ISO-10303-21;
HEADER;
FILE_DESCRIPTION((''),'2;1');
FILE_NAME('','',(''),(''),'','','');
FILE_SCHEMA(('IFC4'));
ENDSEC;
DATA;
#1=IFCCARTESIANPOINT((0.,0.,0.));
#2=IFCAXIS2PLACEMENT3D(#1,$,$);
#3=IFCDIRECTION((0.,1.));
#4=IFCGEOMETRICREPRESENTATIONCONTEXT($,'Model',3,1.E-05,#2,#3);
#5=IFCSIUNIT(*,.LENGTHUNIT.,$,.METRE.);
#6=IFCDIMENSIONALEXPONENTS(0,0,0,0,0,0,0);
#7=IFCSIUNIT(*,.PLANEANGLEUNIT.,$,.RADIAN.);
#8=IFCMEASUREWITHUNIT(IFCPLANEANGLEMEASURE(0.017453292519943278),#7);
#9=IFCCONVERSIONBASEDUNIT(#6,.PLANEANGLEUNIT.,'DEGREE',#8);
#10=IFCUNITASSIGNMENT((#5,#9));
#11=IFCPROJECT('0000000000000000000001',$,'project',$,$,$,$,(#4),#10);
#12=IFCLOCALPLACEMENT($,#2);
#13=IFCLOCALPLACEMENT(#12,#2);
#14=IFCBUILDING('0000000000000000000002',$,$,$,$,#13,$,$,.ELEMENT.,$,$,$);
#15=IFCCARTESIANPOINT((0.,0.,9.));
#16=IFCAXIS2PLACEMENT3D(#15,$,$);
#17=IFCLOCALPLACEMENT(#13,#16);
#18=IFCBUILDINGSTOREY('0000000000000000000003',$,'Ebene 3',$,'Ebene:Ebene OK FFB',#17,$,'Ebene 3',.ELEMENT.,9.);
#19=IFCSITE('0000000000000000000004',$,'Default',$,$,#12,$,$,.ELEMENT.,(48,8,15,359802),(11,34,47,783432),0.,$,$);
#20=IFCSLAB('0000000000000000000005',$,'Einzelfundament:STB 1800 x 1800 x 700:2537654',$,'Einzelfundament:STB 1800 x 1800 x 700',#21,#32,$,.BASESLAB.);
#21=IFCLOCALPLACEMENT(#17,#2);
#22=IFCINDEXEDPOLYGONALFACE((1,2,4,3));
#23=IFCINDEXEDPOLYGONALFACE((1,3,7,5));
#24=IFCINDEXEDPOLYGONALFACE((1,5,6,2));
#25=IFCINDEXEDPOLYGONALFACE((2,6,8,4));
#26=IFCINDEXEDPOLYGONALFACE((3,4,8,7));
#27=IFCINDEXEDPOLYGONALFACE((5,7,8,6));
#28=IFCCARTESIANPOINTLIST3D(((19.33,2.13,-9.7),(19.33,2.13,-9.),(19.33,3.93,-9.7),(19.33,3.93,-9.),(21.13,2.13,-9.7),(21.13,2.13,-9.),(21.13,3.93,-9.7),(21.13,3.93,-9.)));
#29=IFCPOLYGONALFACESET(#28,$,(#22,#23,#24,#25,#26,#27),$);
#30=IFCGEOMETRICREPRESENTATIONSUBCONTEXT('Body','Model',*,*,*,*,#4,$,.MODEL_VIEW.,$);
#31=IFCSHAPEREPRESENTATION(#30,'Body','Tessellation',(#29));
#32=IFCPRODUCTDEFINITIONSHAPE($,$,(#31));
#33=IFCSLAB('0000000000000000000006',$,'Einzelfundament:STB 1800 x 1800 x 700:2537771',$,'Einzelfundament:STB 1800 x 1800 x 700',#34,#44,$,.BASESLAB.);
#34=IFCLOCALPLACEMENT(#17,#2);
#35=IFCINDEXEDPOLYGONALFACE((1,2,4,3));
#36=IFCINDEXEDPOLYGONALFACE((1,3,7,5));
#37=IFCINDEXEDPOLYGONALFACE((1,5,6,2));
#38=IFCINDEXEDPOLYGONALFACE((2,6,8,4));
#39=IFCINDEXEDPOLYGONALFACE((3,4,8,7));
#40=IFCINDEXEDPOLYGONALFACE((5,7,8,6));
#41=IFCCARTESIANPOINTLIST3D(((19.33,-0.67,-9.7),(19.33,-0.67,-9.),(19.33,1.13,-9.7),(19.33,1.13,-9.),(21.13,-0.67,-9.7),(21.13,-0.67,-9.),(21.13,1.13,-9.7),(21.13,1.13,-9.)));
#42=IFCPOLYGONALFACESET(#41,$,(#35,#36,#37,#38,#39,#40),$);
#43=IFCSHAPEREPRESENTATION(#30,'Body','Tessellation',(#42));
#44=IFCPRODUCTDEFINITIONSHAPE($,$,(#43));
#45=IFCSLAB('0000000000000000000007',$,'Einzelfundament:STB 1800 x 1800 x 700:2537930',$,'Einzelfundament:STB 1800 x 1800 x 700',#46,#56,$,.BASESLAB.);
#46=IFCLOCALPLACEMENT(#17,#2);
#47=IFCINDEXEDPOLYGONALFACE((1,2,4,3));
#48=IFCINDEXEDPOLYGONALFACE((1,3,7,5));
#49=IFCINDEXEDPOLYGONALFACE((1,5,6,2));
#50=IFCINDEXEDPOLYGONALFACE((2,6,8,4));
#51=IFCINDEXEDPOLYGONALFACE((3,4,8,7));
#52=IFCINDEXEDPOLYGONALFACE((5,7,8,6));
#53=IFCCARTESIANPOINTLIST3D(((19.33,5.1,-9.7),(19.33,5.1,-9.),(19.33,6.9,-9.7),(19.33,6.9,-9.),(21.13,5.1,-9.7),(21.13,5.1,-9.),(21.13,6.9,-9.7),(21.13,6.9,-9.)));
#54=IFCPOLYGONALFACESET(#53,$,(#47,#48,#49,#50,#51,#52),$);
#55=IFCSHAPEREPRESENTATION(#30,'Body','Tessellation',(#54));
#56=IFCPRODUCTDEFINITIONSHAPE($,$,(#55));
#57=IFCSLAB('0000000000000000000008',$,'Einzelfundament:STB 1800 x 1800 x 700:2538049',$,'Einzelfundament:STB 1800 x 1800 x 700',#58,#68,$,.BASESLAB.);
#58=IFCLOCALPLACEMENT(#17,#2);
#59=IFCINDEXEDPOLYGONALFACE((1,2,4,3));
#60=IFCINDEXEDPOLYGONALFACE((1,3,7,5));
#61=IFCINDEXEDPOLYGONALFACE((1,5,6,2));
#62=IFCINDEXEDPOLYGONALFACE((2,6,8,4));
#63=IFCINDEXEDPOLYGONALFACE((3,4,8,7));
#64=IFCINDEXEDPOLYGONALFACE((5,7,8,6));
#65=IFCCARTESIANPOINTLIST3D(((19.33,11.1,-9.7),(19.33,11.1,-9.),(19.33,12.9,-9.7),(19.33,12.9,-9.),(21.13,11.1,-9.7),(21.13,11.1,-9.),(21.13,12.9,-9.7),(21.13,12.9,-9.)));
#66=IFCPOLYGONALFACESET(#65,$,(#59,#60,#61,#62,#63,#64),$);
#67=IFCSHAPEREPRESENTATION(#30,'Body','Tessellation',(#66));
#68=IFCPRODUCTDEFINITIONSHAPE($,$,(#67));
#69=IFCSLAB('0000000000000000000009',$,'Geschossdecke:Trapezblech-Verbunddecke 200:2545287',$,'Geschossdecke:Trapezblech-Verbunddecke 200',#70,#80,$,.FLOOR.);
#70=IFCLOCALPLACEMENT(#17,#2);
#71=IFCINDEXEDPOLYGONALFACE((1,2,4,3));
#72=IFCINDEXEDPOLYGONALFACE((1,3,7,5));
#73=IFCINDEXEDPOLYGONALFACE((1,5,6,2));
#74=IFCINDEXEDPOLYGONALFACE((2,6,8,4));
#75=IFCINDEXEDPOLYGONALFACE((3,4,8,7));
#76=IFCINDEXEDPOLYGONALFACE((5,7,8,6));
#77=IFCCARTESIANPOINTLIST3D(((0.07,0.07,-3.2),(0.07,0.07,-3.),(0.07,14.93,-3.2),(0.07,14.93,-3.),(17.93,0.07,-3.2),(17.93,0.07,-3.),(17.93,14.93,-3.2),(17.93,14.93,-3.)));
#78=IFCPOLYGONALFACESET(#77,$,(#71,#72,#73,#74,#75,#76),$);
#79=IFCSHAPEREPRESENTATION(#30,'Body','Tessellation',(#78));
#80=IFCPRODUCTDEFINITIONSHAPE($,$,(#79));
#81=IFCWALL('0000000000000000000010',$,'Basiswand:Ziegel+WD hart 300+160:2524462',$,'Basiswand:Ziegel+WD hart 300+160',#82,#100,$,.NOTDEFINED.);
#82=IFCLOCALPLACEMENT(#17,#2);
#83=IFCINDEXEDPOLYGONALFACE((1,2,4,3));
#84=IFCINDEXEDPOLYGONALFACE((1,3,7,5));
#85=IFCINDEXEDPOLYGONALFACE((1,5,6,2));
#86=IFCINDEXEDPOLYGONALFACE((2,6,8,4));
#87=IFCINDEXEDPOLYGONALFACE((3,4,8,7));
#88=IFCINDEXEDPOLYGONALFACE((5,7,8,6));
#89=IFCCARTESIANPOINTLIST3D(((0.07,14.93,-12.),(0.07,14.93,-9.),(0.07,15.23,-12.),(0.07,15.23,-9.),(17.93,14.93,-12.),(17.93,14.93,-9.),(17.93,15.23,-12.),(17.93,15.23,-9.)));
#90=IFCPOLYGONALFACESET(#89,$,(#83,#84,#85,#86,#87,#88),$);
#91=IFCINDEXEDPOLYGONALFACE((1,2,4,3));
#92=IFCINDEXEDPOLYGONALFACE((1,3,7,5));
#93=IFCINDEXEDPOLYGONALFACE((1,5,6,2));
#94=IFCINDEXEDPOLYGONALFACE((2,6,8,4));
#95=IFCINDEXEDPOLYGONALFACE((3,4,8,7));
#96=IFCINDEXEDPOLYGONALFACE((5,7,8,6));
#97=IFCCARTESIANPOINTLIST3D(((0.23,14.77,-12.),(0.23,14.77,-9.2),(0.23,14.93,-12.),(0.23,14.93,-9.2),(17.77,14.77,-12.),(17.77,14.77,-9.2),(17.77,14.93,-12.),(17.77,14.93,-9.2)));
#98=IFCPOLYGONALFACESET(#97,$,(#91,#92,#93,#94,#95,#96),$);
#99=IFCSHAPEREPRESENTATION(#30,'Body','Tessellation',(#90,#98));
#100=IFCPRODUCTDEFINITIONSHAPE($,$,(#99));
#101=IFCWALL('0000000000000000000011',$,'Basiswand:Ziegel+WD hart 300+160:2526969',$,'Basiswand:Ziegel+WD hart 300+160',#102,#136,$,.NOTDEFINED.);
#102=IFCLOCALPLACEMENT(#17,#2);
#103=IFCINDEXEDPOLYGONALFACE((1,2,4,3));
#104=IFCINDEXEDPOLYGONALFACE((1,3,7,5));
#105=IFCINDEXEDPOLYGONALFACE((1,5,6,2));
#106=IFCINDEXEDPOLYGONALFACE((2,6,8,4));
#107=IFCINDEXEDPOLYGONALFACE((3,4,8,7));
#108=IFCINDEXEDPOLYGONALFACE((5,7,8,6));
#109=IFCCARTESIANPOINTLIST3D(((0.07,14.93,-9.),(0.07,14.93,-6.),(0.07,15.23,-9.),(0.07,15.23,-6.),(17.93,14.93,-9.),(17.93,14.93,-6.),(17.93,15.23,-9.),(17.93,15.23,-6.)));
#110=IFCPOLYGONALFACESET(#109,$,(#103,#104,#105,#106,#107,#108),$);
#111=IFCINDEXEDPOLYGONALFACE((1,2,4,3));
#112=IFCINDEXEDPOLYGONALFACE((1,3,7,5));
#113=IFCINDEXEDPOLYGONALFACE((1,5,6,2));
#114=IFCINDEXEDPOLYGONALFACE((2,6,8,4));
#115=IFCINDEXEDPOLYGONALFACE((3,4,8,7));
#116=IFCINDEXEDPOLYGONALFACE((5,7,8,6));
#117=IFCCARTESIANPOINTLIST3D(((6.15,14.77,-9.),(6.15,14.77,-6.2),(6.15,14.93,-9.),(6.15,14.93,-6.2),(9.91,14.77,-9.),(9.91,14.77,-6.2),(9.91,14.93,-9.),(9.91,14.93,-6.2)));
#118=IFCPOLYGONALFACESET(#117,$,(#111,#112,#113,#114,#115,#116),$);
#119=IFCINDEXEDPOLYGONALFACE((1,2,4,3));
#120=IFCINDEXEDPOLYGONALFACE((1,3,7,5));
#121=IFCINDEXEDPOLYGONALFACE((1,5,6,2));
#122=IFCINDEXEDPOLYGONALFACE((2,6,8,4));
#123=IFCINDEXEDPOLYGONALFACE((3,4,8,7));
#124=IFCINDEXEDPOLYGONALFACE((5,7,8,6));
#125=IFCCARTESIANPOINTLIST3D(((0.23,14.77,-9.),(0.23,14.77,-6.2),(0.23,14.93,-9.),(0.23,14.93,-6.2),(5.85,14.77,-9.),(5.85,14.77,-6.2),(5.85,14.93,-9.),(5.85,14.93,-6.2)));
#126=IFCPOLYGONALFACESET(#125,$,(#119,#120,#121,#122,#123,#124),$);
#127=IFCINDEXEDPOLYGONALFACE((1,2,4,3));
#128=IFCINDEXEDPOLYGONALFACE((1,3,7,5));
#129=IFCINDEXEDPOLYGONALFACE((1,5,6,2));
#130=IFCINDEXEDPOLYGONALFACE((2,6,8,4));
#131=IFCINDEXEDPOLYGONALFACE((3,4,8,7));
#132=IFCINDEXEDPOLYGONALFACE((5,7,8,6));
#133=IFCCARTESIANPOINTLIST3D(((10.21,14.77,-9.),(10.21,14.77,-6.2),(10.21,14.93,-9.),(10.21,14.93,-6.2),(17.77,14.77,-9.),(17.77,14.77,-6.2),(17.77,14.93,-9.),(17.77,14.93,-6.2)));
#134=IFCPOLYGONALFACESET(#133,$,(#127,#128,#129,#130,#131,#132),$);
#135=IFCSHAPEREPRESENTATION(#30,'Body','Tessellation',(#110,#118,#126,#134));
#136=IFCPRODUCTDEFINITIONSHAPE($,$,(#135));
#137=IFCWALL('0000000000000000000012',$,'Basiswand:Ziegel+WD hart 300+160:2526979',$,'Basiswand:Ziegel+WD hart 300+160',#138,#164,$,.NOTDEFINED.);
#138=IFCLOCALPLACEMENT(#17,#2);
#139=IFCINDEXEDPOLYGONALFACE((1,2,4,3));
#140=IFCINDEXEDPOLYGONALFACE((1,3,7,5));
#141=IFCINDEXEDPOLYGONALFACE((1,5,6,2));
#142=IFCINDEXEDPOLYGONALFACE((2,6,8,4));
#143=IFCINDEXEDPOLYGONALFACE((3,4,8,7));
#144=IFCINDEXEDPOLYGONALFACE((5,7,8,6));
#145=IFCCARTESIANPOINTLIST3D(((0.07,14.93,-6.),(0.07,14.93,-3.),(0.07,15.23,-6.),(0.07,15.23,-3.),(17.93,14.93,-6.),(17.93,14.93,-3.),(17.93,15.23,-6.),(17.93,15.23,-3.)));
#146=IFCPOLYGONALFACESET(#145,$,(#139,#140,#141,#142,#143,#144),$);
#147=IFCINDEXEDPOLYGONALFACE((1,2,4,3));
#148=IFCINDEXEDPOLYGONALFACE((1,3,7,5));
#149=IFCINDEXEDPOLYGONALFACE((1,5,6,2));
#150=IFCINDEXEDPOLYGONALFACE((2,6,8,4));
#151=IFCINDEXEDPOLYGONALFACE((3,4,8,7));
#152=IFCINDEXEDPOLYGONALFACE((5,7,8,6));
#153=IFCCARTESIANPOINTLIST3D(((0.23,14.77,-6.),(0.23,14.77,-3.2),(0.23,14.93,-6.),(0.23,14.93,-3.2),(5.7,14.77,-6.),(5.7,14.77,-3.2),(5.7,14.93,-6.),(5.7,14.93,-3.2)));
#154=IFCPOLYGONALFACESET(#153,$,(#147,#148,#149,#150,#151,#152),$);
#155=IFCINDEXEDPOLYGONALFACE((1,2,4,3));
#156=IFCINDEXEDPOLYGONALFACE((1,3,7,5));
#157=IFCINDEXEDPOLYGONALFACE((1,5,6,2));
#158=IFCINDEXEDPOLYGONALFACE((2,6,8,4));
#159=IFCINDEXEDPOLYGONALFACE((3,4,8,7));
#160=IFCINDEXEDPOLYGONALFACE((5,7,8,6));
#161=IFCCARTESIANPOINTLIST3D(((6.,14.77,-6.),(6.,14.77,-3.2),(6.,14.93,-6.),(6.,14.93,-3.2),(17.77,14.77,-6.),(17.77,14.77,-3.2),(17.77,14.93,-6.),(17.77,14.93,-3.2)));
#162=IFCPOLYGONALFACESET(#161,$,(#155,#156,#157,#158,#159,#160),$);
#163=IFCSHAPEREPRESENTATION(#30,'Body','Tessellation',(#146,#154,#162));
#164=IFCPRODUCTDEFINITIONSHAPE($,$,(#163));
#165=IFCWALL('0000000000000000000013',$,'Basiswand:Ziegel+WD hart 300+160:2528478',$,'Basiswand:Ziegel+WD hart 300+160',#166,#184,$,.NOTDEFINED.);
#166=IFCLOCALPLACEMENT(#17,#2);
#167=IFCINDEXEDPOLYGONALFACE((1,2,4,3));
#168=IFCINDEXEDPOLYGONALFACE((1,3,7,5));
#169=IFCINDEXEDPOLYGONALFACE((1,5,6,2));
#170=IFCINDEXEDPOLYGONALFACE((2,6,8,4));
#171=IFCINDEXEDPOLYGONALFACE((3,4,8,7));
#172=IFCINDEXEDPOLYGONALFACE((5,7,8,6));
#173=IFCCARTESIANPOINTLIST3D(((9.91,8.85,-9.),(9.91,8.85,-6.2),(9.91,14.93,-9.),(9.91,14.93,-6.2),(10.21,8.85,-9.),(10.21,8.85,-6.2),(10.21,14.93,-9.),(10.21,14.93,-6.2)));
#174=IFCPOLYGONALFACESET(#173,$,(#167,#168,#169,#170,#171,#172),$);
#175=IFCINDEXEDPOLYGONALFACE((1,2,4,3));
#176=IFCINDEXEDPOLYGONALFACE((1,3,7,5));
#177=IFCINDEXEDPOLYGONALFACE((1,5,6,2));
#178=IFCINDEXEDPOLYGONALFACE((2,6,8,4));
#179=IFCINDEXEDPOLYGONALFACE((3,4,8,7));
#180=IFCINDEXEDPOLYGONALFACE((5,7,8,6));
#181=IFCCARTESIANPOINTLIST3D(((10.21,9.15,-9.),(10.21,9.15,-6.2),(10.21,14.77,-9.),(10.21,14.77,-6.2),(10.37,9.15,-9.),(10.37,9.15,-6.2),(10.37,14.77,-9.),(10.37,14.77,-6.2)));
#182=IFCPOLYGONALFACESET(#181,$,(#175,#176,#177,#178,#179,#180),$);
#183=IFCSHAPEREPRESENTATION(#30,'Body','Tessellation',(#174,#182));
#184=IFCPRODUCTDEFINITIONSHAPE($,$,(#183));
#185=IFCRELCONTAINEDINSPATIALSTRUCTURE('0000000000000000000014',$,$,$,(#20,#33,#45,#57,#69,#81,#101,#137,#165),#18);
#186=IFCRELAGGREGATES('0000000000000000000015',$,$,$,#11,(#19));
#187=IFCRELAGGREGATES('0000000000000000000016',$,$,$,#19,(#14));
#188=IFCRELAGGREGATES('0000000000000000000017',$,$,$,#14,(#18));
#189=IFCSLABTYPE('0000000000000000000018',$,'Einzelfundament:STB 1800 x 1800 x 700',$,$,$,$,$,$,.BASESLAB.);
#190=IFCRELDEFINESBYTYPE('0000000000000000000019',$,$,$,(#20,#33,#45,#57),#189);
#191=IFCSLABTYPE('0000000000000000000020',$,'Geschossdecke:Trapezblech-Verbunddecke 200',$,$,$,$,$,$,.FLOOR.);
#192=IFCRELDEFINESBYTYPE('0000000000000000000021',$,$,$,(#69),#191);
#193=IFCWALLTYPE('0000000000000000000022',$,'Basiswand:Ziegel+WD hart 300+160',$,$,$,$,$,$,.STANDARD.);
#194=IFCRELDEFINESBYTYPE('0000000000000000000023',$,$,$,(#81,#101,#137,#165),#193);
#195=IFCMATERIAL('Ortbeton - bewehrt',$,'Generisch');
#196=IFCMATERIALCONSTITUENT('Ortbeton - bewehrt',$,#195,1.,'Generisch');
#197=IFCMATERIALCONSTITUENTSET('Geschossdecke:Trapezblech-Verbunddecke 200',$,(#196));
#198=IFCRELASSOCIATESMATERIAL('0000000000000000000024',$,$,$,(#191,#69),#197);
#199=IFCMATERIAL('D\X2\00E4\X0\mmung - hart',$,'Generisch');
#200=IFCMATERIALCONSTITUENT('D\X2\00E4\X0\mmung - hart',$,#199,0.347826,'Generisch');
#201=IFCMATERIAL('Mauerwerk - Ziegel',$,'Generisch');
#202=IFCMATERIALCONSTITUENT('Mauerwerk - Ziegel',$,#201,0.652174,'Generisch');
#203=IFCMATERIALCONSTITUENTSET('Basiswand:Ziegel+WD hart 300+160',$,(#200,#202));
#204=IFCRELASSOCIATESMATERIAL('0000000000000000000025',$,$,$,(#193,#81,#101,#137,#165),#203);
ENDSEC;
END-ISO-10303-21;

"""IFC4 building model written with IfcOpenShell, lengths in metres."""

from ifc_helpers import new_model, entity, si_unit, converted_unit, direction, frame, origin, place, context, subcontext, project, spatial, indexed_curve, outline, extrude, material, constituent, constituent_set, type_object, element, save


model = new_model("IFC4")

# Units and contexts
model_context = context("Model", 3, precision=1e-05, world=origin(), true_north=direction((0.0, 1.0)))
body_context = subcontext(model_context, "Body", "Model", "MODEL_VIEW")
ifc_project = project(units=[si_unit("LENGTHUNIT", "METRE"), converted_unit("PLANEANGLEUNIT", "DEGREE", entity("IfcPlaneAngleMeasure", 0.017453292519943278), si_unit("PLANEANGLEUNIT", "RADIAN"), dimensions=[0, 0, 0, 0, 0, 0, 0])], contexts=[model_context])

# Site, building, storey
site_placement = place(None, origin())
site = spatial("IfcSite", under=ifc_project, at=site_placement, Name="Default", CompositionType="ELEMENT", RefLatitude=(48, 8, 15, 359802), RefLongitude=(11, 34, 47, 783432), RefElevation=0.0)
building_placement = place(site_placement, origin())
building = spatial("IfcBuilding", under=site, at=building_placement, CompositionType="ELEMENT")
storey_placement = place(building_placement, frame((0.0, 0.0, 9.0)))
storey = spatial("IfcBuildingStorey", under=building, at=storey_placement, Name="Ebene 3", ObjectType="Ebene:Ebene OK FFB", LongName="Ebene 3", CompositionType="ELEMENT", Elevation=9.0)

# Shared definitions
ifc_material_1 = material(Name="Ortbeton - bewehrt", Category="Generisch")

# Slabs
slab_type_1 = type_object("IfcSlabType", Name="Einzelfundament:STB 1800 x 1800 x 700", PredefinedType="BASESLAB")
slab_1_placement = place(storey_placement, origin())
element("IfcSlab", 1, at=slab_1_placement, inside=storey, type_object=slab_type_1, Name="Einzelfundament:STB 1800 x 1800 x 700:2537654", ObjectType="Einzelfundament:STB 1800 x 1800 x 700", PredefinedType="BASESLAB", context=body_context, shape_type="SweptSolid", body=[
    extrude(outline(indexed_curve([(-0.9, -0.9), (0.9, -0.9), (0.9, 0.9), (-0.9, 0.9), (-0.9, -0.9)], self_intersect=False)), frame((20.23, 3.03, -9.7), z_axis=(0.0, 0.0, 1.0), x_axis=(-1.0, 0.0, 0.0)), (0.0, 0.0, 1.0), 0.7),
])
slab_2_placement = place(storey_placement, origin())
element("IfcSlab", 2, at=slab_2_placement, inside=storey, type_object=slab_type_1, Name="Einzelfundament:STB 1800 x 1800 x 700:2537771", ObjectType="Einzelfundament:STB 1800 x 1800 x 700", PredefinedType="BASESLAB", context=body_context, shape_type="SweptSolid", body=[
    extrude(outline(indexed_curve([(-0.9, -0.9), (0.9, -0.9), (0.9, 0.9), (-0.9, 0.9), (-0.9, -0.9)], self_intersect=False)), frame((20.23, 0.23, -9.7), z_axis=(0.0, 0.0, 1.0), x_axis=(-1.0, 0.0, 0.0)), (0.0, 0.0, 1.0), 0.7),
])
slab_3_placement = place(storey_placement, origin())
element("IfcSlab", 3, at=slab_3_placement, inside=storey, type_object=slab_type_1, Name="Einzelfundament:STB 1800 x 1800 x 700:2537930", ObjectType="Einzelfundament:STB 1800 x 1800 x 700", PredefinedType="BASESLAB", context=body_context, shape_type="SweptSolid", body=[
    extrude(outline(indexed_curve([(-0.9, -0.9), (0.9, -0.9), (0.9, 0.9), (-0.9, 0.9), (-0.9, -0.9)], self_intersect=False)), frame((20.23, 6.0, -9.7), z_axis=(0.0, 0.0, 1.0), x_axis=(-1.0, 0.0, 0.0)), (0.0, 0.0, 1.0), 0.7),
])
slab_4_placement = place(storey_placement, origin())
element("IfcSlab", 4, at=slab_4_placement, inside=storey, type_object=slab_type_1, Name="Einzelfundament:STB 1800 x 1800 x 700:2538049", ObjectType="Einzelfundament:STB 1800 x 1800 x 700", PredefinedType="BASESLAB", context=body_context, shape_type="SweptSolid", body=[
    extrude(outline(indexed_curve([(-0.9, -0.9), (0.9, -0.9), (0.9, 0.9), (-0.9, 0.9), (-0.9, -0.9)], self_intersect=False)), frame((20.23, 12.0, -9.7), z_axis=(0.0, 0.0, 1.0), x_axis=(-1.0, 0.0, 0.0)), (0.0, 0.0, 1.0), 0.7),
])
ifc_constituent_1 = constituent(ifc_material_1, Name="Ortbeton - bewehrt", Category="Generisch", fraction=1.0)
ifc_constituent_set_1 = constituent_set(constituents=[ifc_constituent_1], Name="Geschossdecke:Trapezblech-Verbunddecke 200")
slab_type_2 = type_object("IfcSlabType", Name="Geschossdecke:Trapezblech-Verbunddecke 200", PredefinedType="FLOOR", material=ifc_constituent_set_1)
slab_5_placement = place(storey_placement, origin())
element("IfcSlab", 5, at=slab_5_placement, inside=storey, type_object=slab_type_2, material=ifc_constituent_set_1, Name="Geschossdecke:Trapezblech-Verbunddecke 200:2545287", ObjectType="Geschossdecke:Trapezblech-Verbunddecke 200", PredefinedType="FLOOR", context=body_context, shape_type="SweptSolid", body=[
    extrude(outline(indexed_curve([(-7.43, -8.93), (7.43, -8.93), (7.43, 8.93), (-7.43, 8.93), (-7.43, -8.93)], self_intersect=False)), frame((9.0, 7.5, -3.0), z_axis=(0.0, 0.0, -1.0), x_axis=(0.0, 1.0, 0.0)), (0.0, 0.0, 1.0), 0.2),
])

# Walls
ifc_material_2 = material(Name="Dämmung - hart", Category="Generisch")
ifc_constituent_2 = constituent(ifc_material_2, Name="Dämmung - hart", Category="Generisch", fraction=0.347826)
ifc_material_3 = material(Name="Mauerwerk - Ziegel", Category="Generisch")
ifc_constituent_3 = constituent(ifc_material_3, Name="Mauerwerk - Ziegel", Category="Generisch", fraction=0.652174)
ifc_constituent_set_2 = constituent_set(constituents=[ifc_constituent_2, ifc_constituent_3], Name="Basiswand:Ziegel+WD hart 300+160")
wall_type_1 = type_object("IfcWallType", Name="Basiswand:Ziegel+WD hart 300+160", PredefinedType="STANDARD", material=ifc_constituent_set_2)
wall_1_placement = place(storey_placement, frame((17.77, 15.0, -12.0), z_axis=(0.0, 0.0, 1.0), x_axis=(-1.0, 0.0, 0.0)))
element("IfcWall", 6, at=wall_1_placement, inside=storey, type_object=wall_type_1, material=ifc_constituent_set_2, Name="Basiswand:Ziegel+WD hart 300+160:2524462", ObjectType="Basiswand:Ziegel+WD hart 300+160", PredefinedType="NOTDEFINED", context=body_context, shape_type="SweptSolid", body=[
    extrude(outline(indexed_curve([(-0.15, -8.93), (0.15, -8.93), (0.15, 8.93), (-0.15, 8.93), (-0.15, -8.93)], self_intersect=False)), frame((8.77, -0.08, 0.0), z_axis=(0.0, 0.0, 1.0), x_axis=(0.0, 1.0, 0.0)), (0.0, 0.0, 1.0), 3.0),
    extrude(outline(indexed_curve([(-0.08, -8.77), (0.08, -8.77), (0.08, 8.77), (-0.08, 8.77), (-0.08, -8.77)], self_intersect=False)), frame((8.77, 0.15, 0.0), z_axis=(0.0, 0.0, 1.0), x_axis=(0.0, -1.0, 0.0)), (0.0, 0.0, 1.0), 2.8),
])
wall_2_placement = place(storey_placement, frame((17.77, 15.0, -9.0), z_axis=(0.0, 0.0, 1.0), x_axis=(-1.0, 0.0, 0.0)))
element("IfcWall", 7, at=wall_2_placement, inside=storey, type_object=wall_type_1, material=ifc_constituent_set_2, Name="Basiswand:Ziegel+WD hart 300+160:2526969", ObjectType="Basiswand:Ziegel+WD hart 300+160", PredefinedType="NOTDEFINED", context=body_context, shape_type="SweptSolid", body=[
    extrude(outline(indexed_curve([(-0.15, -8.93), (0.15, -8.93), (0.15, 8.93), (-0.15, 8.93), (-0.15, -8.93)], self_intersect=False)), frame((8.77, -0.08, 0.0), z_axis=(0.0, 0.0, 1.0), x_axis=(0.0, 1.0, 0.0)), (0.0, 0.0, 1.0), 3.0),
    extrude(outline(indexed_curve([(-1.88, -0.08), (1.88, -0.08), (1.88, 0.08), (-1.88, 0.08), (-1.88, -0.08)], self_intersect=False)), frame((9.74, 0.15, 0.0)), (0.0, 0.0, 1.0), 2.8),
    extrude(outline(indexed_curve([(-2.81, -0.08), (2.81, -0.08), (2.81, 0.08), (-2.81, 0.08), (-2.81, -0.08)], self_intersect=False)), frame((14.73, 0.15, 0.0), z_axis=(0.0, 0.0, 1.0), x_axis=(-1.0, 0.0, 0.0)), (0.0, 0.0, 1.0), 2.8),
    extrude(outline(indexed_curve([(-3.78, -0.08), (3.78, -0.08), (3.78, 0.08), (-3.78, 0.08), (-3.78, -0.08)], self_intersect=False)), frame((3.78, 0.15, 0.0)), (0.0, 0.0, 1.0), 2.8),
])
wall_3_placement = place(storey_placement, frame((17.77, 15.0, -6.0), z_axis=(0.0, 0.0, 1.0), x_axis=(-1.0, 0.0, 0.0)))
element("IfcWall", 8, at=wall_3_placement, inside=storey, type_object=wall_type_1, material=ifc_constituent_set_2, Name="Basiswand:Ziegel+WD hart 300+160:2526979", ObjectType="Basiswand:Ziegel+WD hart 300+160", PredefinedType="NOTDEFINED", context=body_context, shape_type="SweptSolid", body=[
    extrude(outline(indexed_curve([(-0.15, -8.93), (0.15, -8.93), (0.15, 8.93), (-0.15, 8.93), (-0.15, -8.93)], self_intersect=False)), frame((8.77, -0.08, 0.0), z_axis=(0.0, 0.0, 1.0), x_axis=(0.0, 1.0, 0.0)), (0.0, 0.0, 1.0), 3.0),
    extrude(outline(indexed_curve([(-2.735, -0.08), (2.735, -0.08), (2.735, 0.08), (-2.735, 0.08), (-2.735, -0.08)], self_intersect=False)), frame((14.805, 0.15, 0.0), z_axis=(0.0, 0.0, 1.0), x_axis=(-1.0, 0.0, 0.0)), (0.0, 0.0, 1.0), 2.8),
    extrude(outline(indexed_curve([(-5.885, -0.08), (5.885, -0.08), (5.885, 0.08), (-5.885, 0.08), (-5.885, -0.08)], self_intersect=False)), frame((5.885, 0.15, 0.0)), (0.0, 0.0, 1.0), 2.8),
])

# Wall
wall_4_placement = place(storey_placement, frame((10.14, 14.77, -9.0), z_axis=(0.0, 0.0, 1.0), x_axis=(0.0, -1.0, 0.0)))
element("IfcWall", 9, at=wall_4_placement, inside=storey, type_object=wall_type_1, material=ifc_constituent_set_2, Name="Basiswand:Ziegel+WD hart 300+160:2528478", ObjectType="Basiswand:Ziegel+WD hart 300+160", PredefinedType="NOTDEFINED", context=body_context, shape_type="SweptSolid", body=[
    extrude(outline(indexed_curve([(-1.4, -3.04), (1.4, -3.04), (1.4, 3.04), (-1.4, 3.04), (-1.4, -3.04)], self_intersect=False)), frame((2.88, -0.23, 1.4), z_axis=(0.0, 1.0, 0.0), x_axis=(0.0, 0.0, 1.0)), (0.0, 0.0, 1.0), 0.3),
    extrude(outline(indexed_curve([(-1.4, -2.81), (1.4, -2.81), (1.4, 2.81), (-1.4, 2.81), (-1.4, -2.81)], self_intersect=False)), frame((2.81, 0.07, 1.4), z_axis=(0.0, 1.0, 0.0), x_axis=(0.0, 0.0, 1.0)), (0.0, 0.0, 1.0), 0.16),
])

save(model, "model.ifc")
